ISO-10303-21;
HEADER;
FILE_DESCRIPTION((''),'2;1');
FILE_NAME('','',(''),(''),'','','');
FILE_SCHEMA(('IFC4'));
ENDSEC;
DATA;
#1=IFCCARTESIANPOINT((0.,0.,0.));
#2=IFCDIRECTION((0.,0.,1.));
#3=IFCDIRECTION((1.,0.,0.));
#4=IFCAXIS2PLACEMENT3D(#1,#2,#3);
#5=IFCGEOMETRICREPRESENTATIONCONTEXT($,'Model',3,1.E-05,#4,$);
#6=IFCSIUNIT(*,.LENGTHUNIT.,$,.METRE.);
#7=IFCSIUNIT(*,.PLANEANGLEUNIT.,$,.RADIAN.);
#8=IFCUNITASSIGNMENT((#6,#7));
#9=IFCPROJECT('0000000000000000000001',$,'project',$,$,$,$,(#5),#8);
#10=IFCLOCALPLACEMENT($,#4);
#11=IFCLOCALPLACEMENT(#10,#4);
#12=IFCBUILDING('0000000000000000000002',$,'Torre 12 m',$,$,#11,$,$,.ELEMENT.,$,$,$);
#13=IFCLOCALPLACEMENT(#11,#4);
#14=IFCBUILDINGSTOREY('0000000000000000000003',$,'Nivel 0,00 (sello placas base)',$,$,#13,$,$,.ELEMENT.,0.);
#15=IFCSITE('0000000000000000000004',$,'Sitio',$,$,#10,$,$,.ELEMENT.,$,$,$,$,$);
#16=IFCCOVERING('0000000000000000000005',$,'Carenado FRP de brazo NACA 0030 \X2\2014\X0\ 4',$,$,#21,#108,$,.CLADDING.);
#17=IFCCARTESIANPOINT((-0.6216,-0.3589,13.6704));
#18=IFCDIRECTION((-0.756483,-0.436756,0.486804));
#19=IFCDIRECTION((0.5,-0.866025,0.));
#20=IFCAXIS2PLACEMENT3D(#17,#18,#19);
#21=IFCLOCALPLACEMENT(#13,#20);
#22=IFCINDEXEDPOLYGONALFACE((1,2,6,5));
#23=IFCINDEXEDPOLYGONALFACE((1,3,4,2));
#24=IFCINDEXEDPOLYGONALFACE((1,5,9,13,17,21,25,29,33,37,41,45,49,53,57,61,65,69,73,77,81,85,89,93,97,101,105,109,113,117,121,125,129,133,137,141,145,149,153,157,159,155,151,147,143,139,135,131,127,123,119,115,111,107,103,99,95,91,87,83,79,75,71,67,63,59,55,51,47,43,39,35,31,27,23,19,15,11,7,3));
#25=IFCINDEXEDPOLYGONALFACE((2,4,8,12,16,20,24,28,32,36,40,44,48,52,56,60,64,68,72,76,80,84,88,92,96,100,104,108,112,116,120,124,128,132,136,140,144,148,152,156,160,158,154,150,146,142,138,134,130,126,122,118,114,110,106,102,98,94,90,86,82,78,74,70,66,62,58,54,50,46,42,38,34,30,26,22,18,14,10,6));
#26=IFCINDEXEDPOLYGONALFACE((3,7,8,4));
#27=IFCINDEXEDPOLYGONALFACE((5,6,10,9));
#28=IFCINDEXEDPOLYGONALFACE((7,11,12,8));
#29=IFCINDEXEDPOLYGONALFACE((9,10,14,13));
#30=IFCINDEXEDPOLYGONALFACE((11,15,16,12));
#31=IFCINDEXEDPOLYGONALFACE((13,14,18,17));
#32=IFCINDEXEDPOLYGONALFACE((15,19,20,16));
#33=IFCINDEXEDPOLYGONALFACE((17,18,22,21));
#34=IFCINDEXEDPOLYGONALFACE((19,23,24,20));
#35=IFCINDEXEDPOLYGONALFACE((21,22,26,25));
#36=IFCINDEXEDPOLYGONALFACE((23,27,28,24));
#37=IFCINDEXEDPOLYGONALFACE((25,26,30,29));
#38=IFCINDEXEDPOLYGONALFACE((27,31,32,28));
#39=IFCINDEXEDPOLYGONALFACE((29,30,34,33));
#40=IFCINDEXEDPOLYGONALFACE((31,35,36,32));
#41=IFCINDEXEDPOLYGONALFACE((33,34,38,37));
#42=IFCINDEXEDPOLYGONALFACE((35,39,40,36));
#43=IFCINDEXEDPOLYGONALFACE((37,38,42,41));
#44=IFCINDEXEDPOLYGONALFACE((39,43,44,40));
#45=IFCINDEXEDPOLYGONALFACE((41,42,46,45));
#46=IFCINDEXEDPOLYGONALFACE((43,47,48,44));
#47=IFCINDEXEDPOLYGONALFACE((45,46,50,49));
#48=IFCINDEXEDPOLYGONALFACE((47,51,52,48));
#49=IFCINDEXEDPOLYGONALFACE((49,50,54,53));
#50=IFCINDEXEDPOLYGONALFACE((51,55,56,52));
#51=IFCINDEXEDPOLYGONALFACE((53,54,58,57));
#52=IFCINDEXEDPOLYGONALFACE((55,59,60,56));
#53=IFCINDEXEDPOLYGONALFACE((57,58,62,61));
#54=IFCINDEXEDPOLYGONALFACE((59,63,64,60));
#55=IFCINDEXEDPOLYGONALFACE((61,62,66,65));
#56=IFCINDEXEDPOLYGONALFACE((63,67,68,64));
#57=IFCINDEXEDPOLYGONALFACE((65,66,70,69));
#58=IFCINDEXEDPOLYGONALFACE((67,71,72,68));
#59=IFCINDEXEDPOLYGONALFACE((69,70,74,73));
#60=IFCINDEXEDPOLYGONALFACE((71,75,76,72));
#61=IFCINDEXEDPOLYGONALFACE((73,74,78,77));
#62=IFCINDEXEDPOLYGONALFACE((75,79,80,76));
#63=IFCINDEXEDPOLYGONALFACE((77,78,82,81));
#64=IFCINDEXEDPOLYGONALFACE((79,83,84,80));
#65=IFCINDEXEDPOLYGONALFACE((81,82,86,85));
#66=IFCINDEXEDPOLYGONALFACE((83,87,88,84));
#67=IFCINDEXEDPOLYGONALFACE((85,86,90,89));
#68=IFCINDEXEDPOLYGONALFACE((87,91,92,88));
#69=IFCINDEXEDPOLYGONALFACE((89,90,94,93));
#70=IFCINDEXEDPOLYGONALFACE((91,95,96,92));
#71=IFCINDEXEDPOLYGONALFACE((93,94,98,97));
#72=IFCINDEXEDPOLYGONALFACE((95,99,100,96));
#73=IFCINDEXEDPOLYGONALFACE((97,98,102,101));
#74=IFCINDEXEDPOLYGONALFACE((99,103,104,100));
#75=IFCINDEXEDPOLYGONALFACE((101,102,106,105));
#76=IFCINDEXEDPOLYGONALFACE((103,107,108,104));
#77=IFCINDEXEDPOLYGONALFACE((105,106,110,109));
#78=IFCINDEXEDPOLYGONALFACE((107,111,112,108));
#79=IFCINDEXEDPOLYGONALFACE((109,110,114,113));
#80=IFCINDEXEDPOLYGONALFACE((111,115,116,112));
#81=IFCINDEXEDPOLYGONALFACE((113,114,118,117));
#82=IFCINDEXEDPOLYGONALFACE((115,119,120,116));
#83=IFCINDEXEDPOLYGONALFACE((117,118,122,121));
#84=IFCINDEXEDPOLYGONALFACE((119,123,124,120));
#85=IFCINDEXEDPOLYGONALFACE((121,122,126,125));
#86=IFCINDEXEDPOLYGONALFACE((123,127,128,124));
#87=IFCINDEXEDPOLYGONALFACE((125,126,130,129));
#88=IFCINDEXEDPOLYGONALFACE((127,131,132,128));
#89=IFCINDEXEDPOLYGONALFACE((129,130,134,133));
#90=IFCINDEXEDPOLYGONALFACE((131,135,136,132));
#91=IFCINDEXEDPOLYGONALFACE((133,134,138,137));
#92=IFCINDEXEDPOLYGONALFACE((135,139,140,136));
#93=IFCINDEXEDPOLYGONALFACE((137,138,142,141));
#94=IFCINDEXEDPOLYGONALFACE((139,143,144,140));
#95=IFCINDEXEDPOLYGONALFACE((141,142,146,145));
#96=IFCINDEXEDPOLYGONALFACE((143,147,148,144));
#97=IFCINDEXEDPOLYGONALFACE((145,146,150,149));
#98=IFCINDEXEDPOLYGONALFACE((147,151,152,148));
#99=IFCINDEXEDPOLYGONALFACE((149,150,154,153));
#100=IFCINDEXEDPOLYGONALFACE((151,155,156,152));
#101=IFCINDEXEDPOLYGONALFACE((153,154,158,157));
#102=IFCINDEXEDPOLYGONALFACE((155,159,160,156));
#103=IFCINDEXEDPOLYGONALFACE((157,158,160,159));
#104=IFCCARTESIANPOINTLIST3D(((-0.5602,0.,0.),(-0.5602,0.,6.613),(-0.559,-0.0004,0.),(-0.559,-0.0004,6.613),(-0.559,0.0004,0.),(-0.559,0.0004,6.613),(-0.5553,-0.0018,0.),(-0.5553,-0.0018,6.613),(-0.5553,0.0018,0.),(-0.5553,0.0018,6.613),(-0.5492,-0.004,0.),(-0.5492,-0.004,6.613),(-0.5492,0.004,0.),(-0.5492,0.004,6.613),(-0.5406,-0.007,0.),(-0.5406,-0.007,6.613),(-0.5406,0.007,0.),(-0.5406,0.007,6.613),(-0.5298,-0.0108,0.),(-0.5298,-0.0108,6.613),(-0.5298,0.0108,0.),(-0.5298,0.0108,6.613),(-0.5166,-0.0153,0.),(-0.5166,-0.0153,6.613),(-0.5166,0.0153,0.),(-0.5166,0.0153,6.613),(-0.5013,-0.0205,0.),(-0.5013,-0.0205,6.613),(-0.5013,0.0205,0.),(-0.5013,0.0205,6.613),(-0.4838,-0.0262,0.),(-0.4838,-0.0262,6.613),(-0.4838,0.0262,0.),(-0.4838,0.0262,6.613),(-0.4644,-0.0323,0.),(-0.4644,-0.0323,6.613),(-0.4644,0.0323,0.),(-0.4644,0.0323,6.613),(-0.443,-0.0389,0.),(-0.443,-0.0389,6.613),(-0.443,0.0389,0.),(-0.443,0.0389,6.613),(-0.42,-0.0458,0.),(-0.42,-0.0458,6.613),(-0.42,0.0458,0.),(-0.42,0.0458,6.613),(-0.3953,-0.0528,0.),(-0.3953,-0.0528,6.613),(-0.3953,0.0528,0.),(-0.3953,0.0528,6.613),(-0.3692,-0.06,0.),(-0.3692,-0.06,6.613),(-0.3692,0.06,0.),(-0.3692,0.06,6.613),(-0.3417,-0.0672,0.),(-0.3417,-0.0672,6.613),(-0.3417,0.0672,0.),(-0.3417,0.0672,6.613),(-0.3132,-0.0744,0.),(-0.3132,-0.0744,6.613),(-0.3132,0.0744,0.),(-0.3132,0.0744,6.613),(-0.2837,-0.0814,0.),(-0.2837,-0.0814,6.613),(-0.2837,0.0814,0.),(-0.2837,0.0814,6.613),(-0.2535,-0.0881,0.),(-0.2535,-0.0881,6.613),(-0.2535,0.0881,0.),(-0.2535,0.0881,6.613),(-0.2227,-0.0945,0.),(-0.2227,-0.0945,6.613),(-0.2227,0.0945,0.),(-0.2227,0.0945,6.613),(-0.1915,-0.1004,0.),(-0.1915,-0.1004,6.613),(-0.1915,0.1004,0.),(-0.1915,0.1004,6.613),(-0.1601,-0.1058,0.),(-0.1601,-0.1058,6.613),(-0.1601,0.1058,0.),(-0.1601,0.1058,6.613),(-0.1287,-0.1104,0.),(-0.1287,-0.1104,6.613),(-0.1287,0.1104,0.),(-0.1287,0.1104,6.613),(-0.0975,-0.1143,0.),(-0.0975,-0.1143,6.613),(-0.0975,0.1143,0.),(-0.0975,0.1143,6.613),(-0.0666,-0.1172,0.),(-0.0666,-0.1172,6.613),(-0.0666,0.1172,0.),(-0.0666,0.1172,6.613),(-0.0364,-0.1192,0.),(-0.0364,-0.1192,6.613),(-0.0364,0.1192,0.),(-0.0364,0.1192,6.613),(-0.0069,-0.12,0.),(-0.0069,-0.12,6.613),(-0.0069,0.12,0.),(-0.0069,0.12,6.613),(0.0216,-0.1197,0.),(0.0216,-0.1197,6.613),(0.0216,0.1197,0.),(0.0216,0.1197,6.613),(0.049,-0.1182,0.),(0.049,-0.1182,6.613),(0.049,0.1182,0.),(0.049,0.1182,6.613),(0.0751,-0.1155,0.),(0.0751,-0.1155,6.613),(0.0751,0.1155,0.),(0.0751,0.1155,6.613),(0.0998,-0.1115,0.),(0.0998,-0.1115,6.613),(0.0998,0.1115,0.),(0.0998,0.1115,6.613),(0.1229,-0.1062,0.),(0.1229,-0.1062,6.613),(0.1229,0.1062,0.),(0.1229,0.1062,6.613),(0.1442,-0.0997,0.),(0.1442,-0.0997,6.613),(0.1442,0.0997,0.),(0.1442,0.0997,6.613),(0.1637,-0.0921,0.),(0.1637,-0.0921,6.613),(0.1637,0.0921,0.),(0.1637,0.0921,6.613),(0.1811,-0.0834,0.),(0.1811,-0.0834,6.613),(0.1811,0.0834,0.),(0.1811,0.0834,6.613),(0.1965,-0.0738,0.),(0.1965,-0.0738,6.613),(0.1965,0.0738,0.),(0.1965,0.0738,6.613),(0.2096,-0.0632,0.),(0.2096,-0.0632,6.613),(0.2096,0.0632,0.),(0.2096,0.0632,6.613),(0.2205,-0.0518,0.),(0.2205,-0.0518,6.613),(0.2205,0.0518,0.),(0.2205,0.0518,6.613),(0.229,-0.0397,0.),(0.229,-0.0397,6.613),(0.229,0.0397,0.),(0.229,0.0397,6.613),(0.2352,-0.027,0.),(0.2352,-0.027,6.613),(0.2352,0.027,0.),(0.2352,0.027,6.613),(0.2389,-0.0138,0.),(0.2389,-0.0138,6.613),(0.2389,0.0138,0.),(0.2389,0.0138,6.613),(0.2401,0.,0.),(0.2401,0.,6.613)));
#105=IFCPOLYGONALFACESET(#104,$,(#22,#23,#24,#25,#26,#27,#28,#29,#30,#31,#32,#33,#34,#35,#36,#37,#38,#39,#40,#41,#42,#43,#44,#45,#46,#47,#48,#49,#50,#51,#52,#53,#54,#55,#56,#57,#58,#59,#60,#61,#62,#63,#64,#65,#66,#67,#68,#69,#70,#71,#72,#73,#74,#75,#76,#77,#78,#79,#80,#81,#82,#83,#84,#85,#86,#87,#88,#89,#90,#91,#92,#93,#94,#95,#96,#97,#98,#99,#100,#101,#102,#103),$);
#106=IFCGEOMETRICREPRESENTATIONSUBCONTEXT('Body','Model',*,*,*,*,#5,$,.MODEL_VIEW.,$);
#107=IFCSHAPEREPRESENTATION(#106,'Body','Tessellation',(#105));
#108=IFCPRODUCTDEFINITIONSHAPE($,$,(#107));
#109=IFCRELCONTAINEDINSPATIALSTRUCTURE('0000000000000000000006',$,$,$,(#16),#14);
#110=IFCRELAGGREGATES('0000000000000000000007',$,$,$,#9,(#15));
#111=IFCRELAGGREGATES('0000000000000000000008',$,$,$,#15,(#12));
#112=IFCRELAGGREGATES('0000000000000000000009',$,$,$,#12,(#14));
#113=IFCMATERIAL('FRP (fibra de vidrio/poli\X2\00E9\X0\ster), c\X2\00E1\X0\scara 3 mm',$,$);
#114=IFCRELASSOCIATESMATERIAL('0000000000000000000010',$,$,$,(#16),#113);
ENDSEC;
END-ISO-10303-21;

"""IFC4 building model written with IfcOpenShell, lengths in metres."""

from ifc_helpers import new_model, si_unit, frame, origin, origin_with_axes, place, context, subcontext, project, spatial, polyline, outline, extrude, material, element, save


model = new_model("IFC4")

# Units and contexts
model_context = context("Model", 3, precision=1e-05, world=origin_with_axes())
body_context = subcontext(model_context, "Body", "Model", "MODEL_VIEW")
ifc_project = project(units=[si_unit("LENGTHUNIT", "METRE"), si_unit("PLANEANGLEUNIT", "RADIAN")], contexts=[model_context])

# Site, building, storey
site_placement = place(None, origin_with_axes())
site = spatial("IfcSite", under=ifc_project, at=site_placement, Name="Sitio", CompositionType="ELEMENT")
building_placement = place(site_placement, origin_with_axes())
building = spatial("IfcBuilding", under=site, at=building_placement, Name="Torre 12 m", CompositionType="ELEMENT")
storey_placement = place(building_placement, origin_with_axes())
storey = spatial("IfcBuildingStorey", under=building, at=storey_placement, Name="Nivel 0,00 (sello placas base)", CompositionType="ELEMENT", Elevation=0.0)

# Covering
ifc_material_1 = material(Name="FRP (fibra de vidrio/poliéster), cáscara 3 mm")
covering_1_placement = place(storey_placement, frame((-0.6216, -0.3589, 13.6704), z_axis=(-0.756483, -0.436756, 0.486804), x_axis=(0.5, -0.866025, 0.0)))
element("IfcCovering", 1, at=covering_1_placement, inside=storey, material=ifc_material_1, Name="Carenado FRP de brazo NACA 0030 — 4", PredefinedType="CLADDING", context=body_context, shape_type="SweptSolid", body=[
    extrude(outline(polyline([(0.2401, 0.0), (0.2389, 0.0138), (0.2352, 0.027), (0.229, 0.0397), (0.2205, 0.0518), (0.2096, 0.0632), (0.1965, 0.0738), (0.1811, 0.0834), (0.1637, 0.0921), (0.1442, 0.0997), (0.1229, 0.1062), (0.0998, 0.1115), (0.0751, 0.1155), (0.049, 0.1182), (0.0216, 0.1197), (-0.0069, 0.12), (-0.0364, 0.1192), (-0.0666, 0.1172), (-0.0975, 0.1143), (-0.1287, 0.1104), (-0.1601, 0.1058), (-0.1915, 0.1004), (-0.2227, 0.0945), (-0.2535, 0.0881), (-0.2837, 0.0814), (-0.3132, 0.0744), (-0.3417, 0.0672), (-0.3692, 0.06), (-0.3953, 0.0528), (-0.42, 0.0458), (-0.443, 0.0389), (-0.4644, 0.0323), (-0.4838, 0.0262), (-0.5013, 0.0205), (-0.5166, 0.0153), (-0.5298, 0.0108), (-0.5406, 0.007), (-0.5492, 0.004), (-0.5553, 0.0018), (-0.559, 0.0004), (-0.5602, 0.0), (-0.559, -0.0004), (-0.5553, -0.0018), (-0.5492, -0.004), (-0.5406, -0.007), (-0.5298, -0.0108), (-0.5166, -0.0153), (-0.5013, -0.0205), (-0.4838, -0.0262), (-0.4644, -0.0323), (-0.443, -0.0389), (-0.42, -0.0458), (-0.3953, -0.0528), (-0.3692, -0.06), (-0.3417, -0.0672), (-0.3132, -0.0744), (-0.2837, -0.0814), (-0.2535, -0.0881), (-0.2227, -0.0945), (-0.1915, -0.1004), (-0.1601, -0.1058), (-0.1287, -0.1104), (-0.0975, -0.1143), (-0.0666, -0.1172), (-0.0364, -0.1192), (-0.0069, -0.12), (0.0216, -0.1197), (0.049, -0.1182), (0.0751, -0.1155), (0.0998, -0.1115), (0.1229, -0.1062), (0.1442, -0.0997), (0.1637, -0.0921), (0.1811, -0.0834), (0.1965, -0.0738), (0.2096, -0.0632), (0.2205, -0.0518), (0.229, -0.0397), (0.2352, -0.027), (0.2389, -0.0138), (0.2401, 0.0)])), origin(), (0.0, 0.0, 1.0), 6.613),
])

save(model, "model.ifc")
